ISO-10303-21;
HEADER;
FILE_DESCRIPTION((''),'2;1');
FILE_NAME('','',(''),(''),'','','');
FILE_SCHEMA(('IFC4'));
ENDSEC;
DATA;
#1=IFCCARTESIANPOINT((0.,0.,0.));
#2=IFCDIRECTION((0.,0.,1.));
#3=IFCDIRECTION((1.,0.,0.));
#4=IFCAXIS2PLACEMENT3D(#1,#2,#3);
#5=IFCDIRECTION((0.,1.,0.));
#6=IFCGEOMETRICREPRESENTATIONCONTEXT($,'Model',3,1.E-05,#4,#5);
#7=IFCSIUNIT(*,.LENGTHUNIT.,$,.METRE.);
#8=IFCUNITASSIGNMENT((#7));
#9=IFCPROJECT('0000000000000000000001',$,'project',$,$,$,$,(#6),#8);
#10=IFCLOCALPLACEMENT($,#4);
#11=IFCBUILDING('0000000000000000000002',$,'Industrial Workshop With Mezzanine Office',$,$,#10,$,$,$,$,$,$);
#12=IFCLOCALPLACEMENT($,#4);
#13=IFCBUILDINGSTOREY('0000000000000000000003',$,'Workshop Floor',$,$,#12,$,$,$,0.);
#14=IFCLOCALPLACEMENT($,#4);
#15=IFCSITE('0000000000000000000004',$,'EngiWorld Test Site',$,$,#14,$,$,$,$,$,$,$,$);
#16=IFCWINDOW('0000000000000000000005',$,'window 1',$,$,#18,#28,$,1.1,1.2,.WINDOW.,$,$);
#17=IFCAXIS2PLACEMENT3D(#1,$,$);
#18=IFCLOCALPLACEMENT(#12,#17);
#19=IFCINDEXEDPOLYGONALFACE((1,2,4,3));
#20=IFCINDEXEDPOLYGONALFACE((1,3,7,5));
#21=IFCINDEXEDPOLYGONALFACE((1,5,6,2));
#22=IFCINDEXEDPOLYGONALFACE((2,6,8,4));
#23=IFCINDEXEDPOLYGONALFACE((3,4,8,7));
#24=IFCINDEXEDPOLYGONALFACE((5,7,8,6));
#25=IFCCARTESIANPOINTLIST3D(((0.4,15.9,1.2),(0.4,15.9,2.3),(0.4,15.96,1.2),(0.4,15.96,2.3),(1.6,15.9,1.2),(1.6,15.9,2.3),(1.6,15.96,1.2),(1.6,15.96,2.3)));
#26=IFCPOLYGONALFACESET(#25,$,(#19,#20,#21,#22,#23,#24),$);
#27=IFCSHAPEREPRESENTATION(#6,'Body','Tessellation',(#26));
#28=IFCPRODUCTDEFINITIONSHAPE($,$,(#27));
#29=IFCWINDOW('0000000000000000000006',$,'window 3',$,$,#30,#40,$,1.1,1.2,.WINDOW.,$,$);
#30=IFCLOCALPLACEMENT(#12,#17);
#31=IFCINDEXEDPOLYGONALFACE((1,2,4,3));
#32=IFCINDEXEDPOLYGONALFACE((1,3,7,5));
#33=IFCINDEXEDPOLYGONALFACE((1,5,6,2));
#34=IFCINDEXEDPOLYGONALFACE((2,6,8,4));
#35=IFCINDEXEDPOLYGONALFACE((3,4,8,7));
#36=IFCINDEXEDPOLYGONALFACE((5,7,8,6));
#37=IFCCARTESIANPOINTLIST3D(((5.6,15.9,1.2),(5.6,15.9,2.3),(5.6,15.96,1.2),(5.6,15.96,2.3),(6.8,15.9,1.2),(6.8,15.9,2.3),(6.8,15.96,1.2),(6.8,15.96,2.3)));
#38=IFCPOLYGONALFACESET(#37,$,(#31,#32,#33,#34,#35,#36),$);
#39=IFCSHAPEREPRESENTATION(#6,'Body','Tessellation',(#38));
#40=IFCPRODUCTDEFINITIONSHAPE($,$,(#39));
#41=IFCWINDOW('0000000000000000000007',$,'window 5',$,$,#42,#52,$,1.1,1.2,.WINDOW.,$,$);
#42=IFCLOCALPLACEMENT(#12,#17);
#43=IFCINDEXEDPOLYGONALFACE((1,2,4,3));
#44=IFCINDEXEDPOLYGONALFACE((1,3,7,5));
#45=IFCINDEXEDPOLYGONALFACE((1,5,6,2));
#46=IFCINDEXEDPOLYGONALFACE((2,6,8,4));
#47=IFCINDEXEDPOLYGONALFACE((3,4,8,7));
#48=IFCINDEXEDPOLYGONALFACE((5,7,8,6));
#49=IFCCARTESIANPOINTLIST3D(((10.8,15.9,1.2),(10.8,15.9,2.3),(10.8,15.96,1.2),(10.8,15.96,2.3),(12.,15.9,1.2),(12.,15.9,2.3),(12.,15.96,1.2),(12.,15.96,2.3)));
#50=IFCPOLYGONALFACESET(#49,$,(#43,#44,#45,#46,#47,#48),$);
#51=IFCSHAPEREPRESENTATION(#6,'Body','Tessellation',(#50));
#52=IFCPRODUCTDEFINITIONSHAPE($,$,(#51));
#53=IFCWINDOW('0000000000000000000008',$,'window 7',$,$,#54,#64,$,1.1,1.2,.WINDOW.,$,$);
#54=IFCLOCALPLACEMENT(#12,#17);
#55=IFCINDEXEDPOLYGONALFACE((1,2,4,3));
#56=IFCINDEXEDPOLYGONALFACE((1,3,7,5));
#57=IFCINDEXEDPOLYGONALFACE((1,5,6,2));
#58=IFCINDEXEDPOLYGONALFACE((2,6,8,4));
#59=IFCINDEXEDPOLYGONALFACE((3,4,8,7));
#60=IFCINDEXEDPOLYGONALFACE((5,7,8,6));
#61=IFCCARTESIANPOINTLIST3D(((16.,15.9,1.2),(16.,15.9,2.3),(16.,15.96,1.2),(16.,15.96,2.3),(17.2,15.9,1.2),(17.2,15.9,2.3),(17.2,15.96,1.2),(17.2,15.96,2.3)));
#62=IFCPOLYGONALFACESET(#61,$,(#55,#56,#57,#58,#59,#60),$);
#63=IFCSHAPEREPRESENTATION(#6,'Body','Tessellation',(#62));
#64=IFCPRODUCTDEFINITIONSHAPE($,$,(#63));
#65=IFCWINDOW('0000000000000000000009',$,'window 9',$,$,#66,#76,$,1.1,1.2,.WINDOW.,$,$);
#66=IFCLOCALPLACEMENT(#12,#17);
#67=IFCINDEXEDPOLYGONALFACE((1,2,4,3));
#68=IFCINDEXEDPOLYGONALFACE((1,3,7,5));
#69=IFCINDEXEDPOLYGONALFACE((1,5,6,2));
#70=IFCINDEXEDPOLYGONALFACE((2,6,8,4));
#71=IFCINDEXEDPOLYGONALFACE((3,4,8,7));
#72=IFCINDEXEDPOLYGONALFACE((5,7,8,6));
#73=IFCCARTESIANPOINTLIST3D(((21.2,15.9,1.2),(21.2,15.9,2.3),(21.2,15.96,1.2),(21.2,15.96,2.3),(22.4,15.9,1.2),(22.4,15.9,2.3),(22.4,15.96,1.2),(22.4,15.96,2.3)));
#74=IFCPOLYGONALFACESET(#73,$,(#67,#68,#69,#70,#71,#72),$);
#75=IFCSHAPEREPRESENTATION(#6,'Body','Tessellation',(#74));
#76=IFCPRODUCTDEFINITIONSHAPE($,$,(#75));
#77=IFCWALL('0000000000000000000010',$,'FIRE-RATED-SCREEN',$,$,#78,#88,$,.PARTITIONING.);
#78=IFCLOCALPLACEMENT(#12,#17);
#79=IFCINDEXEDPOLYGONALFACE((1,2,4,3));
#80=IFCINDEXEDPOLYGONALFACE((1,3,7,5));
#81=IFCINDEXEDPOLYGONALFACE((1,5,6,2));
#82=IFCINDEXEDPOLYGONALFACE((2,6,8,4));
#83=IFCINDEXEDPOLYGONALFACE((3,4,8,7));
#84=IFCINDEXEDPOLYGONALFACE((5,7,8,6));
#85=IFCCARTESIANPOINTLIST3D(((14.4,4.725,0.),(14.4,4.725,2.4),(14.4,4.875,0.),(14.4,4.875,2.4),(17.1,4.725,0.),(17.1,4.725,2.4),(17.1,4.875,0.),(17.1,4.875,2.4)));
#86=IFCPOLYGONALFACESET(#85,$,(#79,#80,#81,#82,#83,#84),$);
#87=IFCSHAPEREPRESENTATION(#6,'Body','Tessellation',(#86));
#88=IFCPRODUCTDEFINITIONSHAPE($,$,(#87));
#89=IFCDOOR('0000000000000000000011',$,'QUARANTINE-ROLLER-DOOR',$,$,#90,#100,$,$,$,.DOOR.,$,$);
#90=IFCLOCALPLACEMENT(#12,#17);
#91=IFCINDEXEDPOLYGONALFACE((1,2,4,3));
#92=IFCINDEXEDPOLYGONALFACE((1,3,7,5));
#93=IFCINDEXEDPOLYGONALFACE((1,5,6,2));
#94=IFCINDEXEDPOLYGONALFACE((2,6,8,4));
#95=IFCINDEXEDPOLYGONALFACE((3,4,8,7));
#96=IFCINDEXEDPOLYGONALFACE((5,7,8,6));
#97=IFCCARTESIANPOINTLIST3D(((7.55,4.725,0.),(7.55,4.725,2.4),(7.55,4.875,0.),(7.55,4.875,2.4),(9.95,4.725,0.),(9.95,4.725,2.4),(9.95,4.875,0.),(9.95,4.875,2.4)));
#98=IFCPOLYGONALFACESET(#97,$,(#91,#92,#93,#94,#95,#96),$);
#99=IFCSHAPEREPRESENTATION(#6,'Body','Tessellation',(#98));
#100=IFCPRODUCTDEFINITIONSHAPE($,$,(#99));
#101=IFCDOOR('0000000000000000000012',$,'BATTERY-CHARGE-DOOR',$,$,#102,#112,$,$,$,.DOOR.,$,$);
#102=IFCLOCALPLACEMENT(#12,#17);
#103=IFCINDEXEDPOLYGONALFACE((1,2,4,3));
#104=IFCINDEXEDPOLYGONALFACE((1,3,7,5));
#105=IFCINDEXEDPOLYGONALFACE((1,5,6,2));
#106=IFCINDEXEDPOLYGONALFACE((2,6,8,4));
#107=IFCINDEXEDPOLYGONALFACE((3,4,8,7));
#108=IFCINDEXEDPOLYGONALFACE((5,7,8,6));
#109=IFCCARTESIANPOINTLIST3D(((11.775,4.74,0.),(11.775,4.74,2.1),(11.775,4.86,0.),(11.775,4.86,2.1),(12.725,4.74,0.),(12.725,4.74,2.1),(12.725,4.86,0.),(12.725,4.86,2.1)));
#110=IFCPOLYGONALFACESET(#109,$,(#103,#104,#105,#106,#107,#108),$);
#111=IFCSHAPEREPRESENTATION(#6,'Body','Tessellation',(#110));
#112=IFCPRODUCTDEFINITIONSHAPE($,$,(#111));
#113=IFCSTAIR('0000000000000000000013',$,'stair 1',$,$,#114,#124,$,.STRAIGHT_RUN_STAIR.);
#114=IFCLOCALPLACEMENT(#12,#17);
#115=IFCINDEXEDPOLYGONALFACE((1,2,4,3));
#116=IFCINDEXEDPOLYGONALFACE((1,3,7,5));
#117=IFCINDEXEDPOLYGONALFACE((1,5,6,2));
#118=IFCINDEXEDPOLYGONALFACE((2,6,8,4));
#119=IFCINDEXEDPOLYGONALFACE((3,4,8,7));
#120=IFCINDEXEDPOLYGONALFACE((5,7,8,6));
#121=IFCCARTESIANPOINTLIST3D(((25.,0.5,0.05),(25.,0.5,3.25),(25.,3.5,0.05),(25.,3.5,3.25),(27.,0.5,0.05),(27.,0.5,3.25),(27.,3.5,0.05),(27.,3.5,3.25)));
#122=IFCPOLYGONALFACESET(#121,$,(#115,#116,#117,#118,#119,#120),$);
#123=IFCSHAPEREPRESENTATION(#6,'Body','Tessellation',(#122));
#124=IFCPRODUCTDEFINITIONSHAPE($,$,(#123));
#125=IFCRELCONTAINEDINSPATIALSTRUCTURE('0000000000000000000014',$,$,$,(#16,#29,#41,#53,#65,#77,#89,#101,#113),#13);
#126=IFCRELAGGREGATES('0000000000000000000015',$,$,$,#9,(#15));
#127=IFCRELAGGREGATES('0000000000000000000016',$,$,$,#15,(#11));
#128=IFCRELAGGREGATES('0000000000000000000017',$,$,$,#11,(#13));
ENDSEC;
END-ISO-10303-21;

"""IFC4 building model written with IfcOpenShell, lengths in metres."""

from ifc_helpers import new_model, si_unit, direction, frame, origin, origin_with_axes, origin_2d, origin_2d_with_axis, place, context, project, spatial, rectangle, extrude, element, save


model = new_model("IFC4")

# Units and contexts
model_context = context("Model", 3, precision=1e-05, world=origin_with_axes(), true_north=direction((0.0, 1.0, 0.0)))
ifc_project = project(units=[si_unit("LENGTHUNIT", "METRE")], contexts=[model_context])

# Site, building, storey
site_placement = place(None, origin_with_axes())
site = spatial("IfcSite", under=ifc_project, at=site_placement, Name="EngiWorld Test Site")
building_placement = place(None, origin_with_axes())
building = spatial("IfcBuilding", under=site, at=building_placement, Name="Industrial Workshop With Mezzanine Office")
storey_placement = place(None, origin_with_axes())
storey = spatial("IfcBuildingStorey", under=building, at=storey_placement, Name="Workshop Floor", Elevation=0.0)

# Windows
for number, where, z_axis, x_axis, name in (
    (1, (1.0, 15.93, 1.2), (0.0, 0.0, 1.0), (1.0, 0.0, 0.0), "window 1"),
    (2, (6.2, 15.93, 1.2), (0.0, 0.0, 1.0), (1.0, 0.0, 0.0), "window 3"),
    (3, (11.4, 15.93, 1.2), (0.0, 0.0, 1.0), (1.0, 0.0, 0.0), "window 5"),
    (4, (16.6, 15.93, 1.2), (0.0, 0.0, 1.0), (1.0, 0.0, 0.0), "window 7"),
    (5, (21.8, 15.93, 1.2), (0.0, 0.0, 1.0), (1.0, 0.0, 0.0), "window 9"),
):
    element("IfcWindow", number, at=place(None, frame(where, z_axis=z_axis, x_axis=x_axis)), inside=storey, Name=name, OverallHeight=1.1, OverallWidth=1.2, PredefinedType="WINDOW", context=model_context, shape_type="SweptSolid", body=[
        extrude(rectangle(XDim=1.2, YDim=0.06, at=origin_2d_with_axis()), origin_with_axes(), (0.0, 0.0, 1.0), 1.1),
    ])

# Wall
wall_1_placement = place(None, frame((15.75, 4.8, 0.0)))
element("IfcWall", 6, at=wall_1_placement, inside=storey, Name="FIRE-RATED-SCREEN", PredefinedType="PARTITIONING", context=model_context, shape_type="SweptSolid", body=[
    extrude(rectangle(XDim=2.7, YDim=0.15, at=origin_2d()), origin(), (0.0, 0.0, 1.0), 2.4),
])

# Doors
door_1_placement = place(None, frame((8.75, 4.8, 0.0)))
element("IfcDoor", 7, at=door_1_placement, inside=storey, Name="QUARANTINE-ROLLER-DOOR", PredefinedType="DOOR", context=model_context, shape_type="SweptSolid", body=[
    extrude(rectangle(XDim=2.4, YDim=0.15, at=origin_2d()), origin(), (0.0, 0.0, 1.0), 2.4),
])
door_2_placement = place(None, frame((12.25, 4.8, 0.0)))
element("IfcDoor", 8, at=door_2_placement, inside=storey, Name="BATTERY-CHARGE-DOOR", PredefinedType="DOOR", context=model_context, shape_type="SweptSolid", body=[
    extrude(rectangle(XDim=0.95, YDim=0.12, at=origin_2d()), origin(), (0.0, 0.0, 1.0), 2.1),
])

# Stair
stair_placement = place(None, frame((26.0, 2.0, 0.05), z_axis=(0.0, 0.0, 1.0), x_axis=(1.0, 0.0, 0.0)))
element("IfcStair", 9, at=stair_placement, inside=storey, Name="stair 1", PredefinedType="STRAIGHT_RUN_STAIR", context=model_context, shape_type="SweptSolid", body=[
    extrude(rectangle(XDim=2.0, YDim=3.0, at=origin_2d_with_axis()), origin_with_axes(), (0.0, 0.0, 1.0), 3.2),
])

save(model, "model.ifc")
